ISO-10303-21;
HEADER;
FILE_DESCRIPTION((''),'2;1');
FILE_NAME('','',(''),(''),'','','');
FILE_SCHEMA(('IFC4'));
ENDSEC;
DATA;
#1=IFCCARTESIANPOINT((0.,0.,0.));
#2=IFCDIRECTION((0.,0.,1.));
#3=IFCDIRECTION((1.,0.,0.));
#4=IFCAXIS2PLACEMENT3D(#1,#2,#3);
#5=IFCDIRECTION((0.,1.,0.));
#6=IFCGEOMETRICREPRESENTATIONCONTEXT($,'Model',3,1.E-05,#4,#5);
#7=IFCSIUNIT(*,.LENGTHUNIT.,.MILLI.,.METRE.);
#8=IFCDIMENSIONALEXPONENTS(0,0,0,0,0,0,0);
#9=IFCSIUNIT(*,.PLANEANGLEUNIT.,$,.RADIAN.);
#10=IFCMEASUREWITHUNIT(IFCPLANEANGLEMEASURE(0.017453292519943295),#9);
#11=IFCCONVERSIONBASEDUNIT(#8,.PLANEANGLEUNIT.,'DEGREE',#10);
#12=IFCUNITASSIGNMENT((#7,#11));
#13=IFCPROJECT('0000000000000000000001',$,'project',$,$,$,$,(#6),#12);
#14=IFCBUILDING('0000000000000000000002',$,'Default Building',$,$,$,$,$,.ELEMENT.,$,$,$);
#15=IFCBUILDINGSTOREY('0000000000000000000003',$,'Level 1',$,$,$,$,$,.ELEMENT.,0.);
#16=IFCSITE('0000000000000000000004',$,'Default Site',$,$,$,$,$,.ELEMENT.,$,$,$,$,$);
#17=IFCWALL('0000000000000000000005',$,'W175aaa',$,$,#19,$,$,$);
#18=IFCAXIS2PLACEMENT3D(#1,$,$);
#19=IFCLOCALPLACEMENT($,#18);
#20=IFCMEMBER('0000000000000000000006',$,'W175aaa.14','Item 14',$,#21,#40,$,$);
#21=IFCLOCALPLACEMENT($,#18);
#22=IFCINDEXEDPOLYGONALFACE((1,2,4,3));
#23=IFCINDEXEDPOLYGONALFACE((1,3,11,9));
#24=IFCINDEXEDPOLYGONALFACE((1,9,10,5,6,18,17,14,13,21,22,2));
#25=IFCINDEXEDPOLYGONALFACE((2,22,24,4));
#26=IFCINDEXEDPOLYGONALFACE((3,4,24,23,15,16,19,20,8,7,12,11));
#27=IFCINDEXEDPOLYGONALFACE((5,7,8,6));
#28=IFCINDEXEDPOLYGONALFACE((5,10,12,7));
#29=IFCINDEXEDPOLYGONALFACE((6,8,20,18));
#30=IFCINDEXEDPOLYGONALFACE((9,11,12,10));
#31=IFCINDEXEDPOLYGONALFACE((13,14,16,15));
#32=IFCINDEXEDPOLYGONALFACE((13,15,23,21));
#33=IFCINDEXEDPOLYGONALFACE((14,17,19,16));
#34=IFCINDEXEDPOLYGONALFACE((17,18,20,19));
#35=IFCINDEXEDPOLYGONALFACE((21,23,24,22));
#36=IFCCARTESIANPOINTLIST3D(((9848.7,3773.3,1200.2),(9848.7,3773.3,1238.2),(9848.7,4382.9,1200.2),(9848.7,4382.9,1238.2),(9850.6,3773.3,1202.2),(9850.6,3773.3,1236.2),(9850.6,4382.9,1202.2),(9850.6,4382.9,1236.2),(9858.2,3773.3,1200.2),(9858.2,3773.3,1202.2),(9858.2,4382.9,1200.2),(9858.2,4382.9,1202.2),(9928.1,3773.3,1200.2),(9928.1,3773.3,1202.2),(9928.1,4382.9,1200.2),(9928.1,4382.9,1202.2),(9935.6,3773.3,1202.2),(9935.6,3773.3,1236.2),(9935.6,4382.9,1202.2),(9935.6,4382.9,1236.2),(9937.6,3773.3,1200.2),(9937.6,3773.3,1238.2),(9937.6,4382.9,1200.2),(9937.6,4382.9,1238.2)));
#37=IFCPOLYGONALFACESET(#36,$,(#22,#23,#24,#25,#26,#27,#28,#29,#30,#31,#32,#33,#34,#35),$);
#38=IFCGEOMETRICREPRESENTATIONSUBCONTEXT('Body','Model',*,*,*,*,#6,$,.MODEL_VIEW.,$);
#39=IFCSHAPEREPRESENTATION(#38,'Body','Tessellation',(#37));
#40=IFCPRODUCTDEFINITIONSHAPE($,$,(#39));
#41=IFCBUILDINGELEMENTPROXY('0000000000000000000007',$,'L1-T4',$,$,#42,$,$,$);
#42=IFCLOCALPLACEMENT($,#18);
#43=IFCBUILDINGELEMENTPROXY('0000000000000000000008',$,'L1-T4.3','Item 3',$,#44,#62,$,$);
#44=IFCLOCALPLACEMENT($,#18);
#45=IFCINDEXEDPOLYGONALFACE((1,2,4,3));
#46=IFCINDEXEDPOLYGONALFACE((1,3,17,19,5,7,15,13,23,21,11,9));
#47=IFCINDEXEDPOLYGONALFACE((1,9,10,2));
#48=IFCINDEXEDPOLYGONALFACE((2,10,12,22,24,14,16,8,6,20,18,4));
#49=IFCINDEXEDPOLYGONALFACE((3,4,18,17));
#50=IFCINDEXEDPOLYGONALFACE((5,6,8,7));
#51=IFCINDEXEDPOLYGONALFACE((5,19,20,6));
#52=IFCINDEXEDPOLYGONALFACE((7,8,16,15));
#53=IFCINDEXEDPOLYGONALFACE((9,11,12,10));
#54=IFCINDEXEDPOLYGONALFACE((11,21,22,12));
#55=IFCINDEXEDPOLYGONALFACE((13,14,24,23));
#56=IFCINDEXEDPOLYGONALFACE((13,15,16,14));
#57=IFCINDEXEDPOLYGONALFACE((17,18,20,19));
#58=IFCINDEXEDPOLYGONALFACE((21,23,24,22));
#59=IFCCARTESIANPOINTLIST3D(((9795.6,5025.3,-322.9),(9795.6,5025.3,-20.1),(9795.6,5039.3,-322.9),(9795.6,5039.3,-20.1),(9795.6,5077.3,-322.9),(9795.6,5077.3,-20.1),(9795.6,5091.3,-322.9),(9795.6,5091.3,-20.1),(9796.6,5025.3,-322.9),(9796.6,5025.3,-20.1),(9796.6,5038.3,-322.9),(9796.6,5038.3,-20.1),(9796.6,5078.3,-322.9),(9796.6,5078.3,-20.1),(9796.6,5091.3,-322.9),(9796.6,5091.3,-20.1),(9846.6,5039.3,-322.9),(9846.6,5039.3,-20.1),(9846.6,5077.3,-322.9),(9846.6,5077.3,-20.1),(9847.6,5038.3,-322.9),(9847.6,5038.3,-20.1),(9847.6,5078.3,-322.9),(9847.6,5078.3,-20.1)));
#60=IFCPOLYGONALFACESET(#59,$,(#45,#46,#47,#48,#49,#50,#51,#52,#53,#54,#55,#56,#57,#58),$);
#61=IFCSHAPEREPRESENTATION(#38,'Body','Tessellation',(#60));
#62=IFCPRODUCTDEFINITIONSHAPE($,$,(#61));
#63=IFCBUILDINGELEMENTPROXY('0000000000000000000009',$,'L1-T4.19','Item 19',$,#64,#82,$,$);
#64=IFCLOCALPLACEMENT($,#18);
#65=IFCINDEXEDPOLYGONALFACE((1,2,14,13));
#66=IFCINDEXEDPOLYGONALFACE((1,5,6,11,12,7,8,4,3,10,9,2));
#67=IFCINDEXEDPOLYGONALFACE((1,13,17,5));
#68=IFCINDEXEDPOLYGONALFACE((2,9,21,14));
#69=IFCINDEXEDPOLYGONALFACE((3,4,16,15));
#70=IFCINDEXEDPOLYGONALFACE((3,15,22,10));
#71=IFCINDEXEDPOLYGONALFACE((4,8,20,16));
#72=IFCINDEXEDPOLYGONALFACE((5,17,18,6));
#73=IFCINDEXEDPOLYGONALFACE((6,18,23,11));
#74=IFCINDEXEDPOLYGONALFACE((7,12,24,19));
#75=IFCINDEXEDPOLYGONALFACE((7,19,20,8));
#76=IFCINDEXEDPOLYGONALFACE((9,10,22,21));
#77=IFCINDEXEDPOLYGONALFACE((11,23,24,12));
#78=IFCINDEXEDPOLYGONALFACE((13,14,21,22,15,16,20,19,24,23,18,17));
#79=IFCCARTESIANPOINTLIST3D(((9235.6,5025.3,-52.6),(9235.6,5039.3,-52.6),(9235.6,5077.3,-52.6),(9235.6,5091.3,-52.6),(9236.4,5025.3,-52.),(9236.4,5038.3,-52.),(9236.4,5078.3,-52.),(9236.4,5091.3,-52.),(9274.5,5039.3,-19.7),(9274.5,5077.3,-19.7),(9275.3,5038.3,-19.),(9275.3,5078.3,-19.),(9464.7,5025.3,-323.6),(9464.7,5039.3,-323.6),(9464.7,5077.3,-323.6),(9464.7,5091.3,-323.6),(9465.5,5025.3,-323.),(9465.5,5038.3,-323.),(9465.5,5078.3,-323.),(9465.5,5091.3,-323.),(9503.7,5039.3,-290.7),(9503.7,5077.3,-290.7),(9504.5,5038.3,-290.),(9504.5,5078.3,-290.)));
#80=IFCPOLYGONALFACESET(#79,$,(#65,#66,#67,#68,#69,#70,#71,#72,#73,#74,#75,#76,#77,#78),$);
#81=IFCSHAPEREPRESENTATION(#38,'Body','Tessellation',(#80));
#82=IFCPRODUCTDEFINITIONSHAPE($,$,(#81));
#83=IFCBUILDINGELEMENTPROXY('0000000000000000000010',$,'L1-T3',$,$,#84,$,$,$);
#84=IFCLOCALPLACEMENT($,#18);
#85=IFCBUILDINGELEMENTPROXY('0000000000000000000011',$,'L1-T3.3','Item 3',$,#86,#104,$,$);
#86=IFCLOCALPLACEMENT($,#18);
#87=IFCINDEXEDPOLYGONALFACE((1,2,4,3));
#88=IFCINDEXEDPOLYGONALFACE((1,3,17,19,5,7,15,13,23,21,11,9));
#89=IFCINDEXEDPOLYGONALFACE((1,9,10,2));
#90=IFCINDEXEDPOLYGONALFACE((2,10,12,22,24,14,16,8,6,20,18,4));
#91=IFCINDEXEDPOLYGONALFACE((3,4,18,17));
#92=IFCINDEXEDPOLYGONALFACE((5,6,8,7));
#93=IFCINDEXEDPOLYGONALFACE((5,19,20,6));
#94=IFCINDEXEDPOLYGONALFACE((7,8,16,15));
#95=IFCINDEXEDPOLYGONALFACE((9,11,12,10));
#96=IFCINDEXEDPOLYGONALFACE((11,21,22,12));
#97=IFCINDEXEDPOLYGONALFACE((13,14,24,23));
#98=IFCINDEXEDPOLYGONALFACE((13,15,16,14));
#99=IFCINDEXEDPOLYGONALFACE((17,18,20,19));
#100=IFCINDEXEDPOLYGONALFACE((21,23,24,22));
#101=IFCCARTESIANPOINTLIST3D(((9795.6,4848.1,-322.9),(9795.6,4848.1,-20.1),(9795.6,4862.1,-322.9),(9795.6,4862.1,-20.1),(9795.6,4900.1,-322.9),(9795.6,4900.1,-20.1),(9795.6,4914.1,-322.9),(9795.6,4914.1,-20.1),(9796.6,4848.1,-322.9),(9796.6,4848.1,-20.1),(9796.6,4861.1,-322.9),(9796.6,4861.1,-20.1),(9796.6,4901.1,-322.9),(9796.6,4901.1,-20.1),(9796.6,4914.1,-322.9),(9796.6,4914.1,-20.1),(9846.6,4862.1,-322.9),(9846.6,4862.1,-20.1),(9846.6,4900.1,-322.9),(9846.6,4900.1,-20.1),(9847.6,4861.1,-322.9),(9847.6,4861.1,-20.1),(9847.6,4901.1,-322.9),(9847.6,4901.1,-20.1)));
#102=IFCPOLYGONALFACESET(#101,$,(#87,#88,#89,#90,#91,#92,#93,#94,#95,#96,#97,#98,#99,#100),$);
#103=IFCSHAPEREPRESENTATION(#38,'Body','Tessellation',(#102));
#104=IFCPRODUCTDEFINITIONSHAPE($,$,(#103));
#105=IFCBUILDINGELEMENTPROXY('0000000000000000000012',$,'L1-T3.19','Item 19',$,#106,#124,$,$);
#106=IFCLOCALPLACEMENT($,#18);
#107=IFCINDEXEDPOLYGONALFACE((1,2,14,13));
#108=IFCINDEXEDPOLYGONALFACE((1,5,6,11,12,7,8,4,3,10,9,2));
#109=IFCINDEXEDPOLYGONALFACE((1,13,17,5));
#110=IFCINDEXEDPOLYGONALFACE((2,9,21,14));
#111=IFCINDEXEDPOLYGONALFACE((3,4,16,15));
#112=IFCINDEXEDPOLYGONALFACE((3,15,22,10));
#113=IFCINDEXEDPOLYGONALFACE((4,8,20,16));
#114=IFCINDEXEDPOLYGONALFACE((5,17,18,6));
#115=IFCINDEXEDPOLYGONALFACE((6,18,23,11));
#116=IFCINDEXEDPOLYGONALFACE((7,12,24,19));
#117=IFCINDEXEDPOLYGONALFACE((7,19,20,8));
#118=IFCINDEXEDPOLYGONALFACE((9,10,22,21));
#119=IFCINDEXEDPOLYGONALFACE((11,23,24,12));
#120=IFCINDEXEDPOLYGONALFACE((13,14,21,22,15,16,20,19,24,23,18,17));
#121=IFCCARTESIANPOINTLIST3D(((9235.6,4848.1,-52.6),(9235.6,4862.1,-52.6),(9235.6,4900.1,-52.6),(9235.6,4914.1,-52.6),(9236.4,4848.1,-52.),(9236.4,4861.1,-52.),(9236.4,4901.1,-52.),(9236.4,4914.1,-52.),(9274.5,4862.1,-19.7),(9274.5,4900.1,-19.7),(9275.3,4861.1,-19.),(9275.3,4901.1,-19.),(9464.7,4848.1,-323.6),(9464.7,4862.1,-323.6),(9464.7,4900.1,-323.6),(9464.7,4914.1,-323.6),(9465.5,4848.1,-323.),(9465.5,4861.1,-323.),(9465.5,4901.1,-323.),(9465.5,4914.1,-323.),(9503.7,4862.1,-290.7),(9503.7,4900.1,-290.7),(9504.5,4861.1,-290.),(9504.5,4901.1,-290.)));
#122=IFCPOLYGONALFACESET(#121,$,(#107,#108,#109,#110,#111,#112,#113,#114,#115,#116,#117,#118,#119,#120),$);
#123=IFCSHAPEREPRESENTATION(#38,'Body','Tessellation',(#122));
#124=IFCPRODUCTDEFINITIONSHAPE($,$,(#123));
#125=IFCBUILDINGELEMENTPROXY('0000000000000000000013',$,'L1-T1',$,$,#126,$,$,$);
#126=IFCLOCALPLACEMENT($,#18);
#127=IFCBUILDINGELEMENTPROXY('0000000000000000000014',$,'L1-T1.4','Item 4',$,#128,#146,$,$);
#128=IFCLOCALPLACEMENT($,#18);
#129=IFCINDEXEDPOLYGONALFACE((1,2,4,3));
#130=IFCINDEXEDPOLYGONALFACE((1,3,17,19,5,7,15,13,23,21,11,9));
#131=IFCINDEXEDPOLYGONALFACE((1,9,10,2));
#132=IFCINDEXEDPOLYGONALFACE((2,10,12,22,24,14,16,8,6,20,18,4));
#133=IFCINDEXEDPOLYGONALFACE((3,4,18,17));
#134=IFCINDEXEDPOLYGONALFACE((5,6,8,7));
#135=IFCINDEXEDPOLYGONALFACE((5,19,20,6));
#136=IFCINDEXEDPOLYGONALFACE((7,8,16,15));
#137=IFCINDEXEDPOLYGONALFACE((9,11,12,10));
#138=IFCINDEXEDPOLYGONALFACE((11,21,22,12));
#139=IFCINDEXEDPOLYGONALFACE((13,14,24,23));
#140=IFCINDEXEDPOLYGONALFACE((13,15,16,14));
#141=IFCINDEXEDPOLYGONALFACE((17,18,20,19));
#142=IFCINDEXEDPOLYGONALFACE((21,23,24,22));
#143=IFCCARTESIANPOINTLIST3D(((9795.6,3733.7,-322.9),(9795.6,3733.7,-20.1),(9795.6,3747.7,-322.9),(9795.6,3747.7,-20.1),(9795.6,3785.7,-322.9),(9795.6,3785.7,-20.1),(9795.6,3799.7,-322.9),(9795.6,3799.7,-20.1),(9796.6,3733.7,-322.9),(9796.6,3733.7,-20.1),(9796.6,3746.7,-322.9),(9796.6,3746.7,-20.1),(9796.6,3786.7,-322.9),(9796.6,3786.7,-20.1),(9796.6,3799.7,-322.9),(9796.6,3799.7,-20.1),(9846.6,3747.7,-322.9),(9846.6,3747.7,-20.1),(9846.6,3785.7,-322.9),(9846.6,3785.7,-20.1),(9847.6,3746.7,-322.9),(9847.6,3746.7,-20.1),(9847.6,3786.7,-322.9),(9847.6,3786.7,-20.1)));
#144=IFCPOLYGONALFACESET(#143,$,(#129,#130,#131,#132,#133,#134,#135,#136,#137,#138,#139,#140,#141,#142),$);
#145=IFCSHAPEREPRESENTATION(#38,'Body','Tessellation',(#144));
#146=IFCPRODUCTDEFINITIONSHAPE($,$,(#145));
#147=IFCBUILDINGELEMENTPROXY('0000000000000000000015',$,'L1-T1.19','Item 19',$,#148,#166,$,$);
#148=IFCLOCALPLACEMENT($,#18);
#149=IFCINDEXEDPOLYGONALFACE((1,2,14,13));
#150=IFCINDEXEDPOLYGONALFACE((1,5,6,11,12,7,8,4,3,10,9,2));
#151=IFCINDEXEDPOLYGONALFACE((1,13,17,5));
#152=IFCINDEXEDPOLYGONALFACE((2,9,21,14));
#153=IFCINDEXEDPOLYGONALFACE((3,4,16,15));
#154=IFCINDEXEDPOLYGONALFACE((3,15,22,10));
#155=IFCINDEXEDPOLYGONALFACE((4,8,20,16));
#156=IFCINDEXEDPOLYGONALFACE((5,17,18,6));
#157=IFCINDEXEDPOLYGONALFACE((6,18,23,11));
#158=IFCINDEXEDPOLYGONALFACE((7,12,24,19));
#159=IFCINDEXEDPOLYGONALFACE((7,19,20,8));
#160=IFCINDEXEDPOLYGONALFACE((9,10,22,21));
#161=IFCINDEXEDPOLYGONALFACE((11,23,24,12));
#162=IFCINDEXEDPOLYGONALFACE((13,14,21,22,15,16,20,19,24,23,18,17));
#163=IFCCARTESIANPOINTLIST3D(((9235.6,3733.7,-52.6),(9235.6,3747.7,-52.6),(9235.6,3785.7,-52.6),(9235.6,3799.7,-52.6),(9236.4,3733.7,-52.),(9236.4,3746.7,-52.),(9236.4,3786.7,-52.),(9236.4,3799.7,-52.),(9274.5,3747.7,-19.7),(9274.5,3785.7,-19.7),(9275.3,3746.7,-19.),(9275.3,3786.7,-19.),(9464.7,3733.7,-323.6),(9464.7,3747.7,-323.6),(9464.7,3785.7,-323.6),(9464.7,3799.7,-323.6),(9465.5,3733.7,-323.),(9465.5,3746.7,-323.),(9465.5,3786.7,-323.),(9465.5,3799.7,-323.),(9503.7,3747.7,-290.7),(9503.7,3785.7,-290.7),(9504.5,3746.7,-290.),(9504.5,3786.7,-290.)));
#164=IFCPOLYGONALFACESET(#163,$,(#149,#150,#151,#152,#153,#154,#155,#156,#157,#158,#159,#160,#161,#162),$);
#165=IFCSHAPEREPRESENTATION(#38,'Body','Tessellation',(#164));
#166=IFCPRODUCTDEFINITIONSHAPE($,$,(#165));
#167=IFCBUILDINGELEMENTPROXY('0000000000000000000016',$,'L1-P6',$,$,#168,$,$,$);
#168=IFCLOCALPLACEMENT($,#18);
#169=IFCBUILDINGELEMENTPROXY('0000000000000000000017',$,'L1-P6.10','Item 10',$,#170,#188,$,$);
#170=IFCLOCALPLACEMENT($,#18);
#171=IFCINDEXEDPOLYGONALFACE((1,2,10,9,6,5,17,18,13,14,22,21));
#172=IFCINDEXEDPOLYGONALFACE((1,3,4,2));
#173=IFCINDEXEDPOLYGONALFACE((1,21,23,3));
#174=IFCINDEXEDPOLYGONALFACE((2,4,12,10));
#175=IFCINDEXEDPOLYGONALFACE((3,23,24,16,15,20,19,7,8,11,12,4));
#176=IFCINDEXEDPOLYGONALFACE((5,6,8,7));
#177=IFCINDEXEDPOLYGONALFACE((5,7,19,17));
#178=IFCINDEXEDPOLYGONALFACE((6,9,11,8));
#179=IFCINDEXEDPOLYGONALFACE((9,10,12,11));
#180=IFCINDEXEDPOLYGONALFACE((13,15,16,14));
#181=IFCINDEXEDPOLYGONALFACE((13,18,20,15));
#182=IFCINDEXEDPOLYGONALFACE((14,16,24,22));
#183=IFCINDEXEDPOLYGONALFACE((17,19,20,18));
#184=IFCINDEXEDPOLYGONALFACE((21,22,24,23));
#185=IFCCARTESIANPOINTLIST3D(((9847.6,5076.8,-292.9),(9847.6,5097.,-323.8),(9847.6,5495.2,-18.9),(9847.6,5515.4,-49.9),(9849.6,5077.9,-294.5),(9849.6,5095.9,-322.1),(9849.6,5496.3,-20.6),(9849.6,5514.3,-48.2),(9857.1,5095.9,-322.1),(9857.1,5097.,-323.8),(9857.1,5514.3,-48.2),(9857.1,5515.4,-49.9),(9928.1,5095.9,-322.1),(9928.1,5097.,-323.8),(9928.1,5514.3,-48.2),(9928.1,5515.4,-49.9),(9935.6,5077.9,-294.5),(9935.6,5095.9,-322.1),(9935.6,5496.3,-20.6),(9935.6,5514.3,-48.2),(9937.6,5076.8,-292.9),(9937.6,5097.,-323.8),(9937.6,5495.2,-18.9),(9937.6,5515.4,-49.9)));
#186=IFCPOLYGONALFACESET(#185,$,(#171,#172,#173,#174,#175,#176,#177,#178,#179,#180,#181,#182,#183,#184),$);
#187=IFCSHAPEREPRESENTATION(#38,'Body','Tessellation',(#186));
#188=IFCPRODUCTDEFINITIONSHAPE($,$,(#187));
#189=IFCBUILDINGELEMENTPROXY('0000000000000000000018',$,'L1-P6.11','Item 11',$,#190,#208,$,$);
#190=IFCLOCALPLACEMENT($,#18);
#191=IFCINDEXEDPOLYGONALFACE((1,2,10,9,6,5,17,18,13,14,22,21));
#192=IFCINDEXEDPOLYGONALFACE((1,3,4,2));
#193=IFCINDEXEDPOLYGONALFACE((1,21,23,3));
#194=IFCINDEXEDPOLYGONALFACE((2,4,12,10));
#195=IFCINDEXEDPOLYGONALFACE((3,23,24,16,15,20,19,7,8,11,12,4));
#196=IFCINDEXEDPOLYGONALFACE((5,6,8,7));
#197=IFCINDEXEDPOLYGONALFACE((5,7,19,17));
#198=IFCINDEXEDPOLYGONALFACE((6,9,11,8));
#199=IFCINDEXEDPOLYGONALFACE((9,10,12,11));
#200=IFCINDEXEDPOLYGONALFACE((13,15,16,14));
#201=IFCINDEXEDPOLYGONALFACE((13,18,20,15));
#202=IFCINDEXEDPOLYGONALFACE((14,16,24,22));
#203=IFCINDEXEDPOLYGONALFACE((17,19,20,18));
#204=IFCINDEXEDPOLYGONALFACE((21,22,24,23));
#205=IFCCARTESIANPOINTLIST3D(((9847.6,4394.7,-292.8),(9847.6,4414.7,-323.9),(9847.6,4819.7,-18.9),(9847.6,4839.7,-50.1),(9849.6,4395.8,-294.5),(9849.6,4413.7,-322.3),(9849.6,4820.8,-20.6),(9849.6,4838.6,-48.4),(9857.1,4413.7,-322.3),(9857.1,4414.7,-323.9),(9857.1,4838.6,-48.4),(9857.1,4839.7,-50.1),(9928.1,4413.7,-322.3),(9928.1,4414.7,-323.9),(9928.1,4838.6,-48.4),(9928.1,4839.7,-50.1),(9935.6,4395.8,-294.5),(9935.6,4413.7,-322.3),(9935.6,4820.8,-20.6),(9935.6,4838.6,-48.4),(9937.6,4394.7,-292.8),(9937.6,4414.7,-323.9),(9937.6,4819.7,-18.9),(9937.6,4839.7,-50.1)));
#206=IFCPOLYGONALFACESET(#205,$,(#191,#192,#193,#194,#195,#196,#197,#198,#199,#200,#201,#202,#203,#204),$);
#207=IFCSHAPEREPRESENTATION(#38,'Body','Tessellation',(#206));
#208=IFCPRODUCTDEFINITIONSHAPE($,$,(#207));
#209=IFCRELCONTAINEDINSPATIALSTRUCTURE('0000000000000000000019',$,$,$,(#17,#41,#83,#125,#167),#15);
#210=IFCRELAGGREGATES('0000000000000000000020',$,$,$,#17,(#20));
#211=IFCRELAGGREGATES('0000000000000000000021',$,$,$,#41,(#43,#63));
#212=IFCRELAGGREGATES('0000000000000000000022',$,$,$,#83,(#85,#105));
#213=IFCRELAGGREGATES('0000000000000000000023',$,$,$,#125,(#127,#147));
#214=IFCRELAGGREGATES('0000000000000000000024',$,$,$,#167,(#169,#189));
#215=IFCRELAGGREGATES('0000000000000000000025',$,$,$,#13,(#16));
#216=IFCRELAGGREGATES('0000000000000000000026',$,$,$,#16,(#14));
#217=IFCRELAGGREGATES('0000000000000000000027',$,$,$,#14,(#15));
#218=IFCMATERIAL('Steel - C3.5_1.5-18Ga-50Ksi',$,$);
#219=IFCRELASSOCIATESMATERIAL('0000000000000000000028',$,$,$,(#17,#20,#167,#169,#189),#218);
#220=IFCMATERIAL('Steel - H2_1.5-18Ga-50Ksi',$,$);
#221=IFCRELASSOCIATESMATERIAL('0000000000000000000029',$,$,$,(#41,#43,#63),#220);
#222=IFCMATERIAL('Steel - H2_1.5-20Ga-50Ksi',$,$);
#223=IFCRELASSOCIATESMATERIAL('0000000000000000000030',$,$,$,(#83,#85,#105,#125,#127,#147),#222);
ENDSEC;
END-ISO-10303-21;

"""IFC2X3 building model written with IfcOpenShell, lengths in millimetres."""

from ifc_helpers import new_model, entity, si_unit, converted_unit, direction, frame, origin, origin_with_axes, origin_2d_with_axis, place, context, subcontext, project, spatial, polyline, c_section, outline, extrude, material, element, aggregate, save


model = new_model("IFC2X3")

# Units and contexts
model_context = context("Model", 3, precision=1e-05, world=origin_with_axes(), true_north=direction((0.0, 1.0, 0.0)))
body_context = subcontext(model_context, "Body", "Model", "MODEL_VIEW")
ifc_project = project(units=[si_unit("LENGTHUNIT", "METRE", prefix="MILLI"), converted_unit("PLANEANGLEUNIT", "DEGREE", entity("IfcPlaneAngleMeasure", 0.017453292519943295), si_unit("PLANEANGLEUNIT", "RADIAN"), dimensions=[0, 0, 0, 0, 0, 0, 0])], contexts=[model_context])

# Site, building, storey
site = spatial("IfcSite", under=ifc_project, Name="Default Site", CompositionType="ELEMENT")
building = spatial("IfcBuilding", under=site, Name="Default Building", CompositionType="ELEMENT")
storey = spatial("IfcBuildingStorey", under=building, Name="Level 1", CompositionType="ELEMENT", Elevation=0.0)

# Wall, member
ifc_material_1 = material(Name="Steel - C3.5_1.5-18Ga-50Ksi")
wall = element("IfcWall", 1, inside=storey, material=ifc_material_1, Name="W175aaa")
member_1_placement = place(None, frame((9893.1, 3773.3, 1219.2), z_axis=(0.0, 1.0, 0.0), x_axis=(0.0, 0.0, -1.0)))
member_1 = element("IfcMember", 2, at=member_1_placement, material=ifc_material_1, Name="W175aaa.14", Description="Item 14", context=body_context, shape_type="SweptSolid", body=[
    extrude(c_section(Depth=88.9, Width=38.1, WallThickness=2.0, Girth=9.5, at=origin_2d_with_axis()), origin(), (0.0, 0.0, 1.0), 609.6),
])
aggregate(wall, [member_1])

# Building element proxies
ifc_material_2 = material(Name="Steel - H2_1.5-18Ga-50Ksi")
proxy_1 = element("IfcBuildingElementProxy", 3, inside=storey, material=ifc_material_2, Name="L1-T4")
proxy_2_placement = place(None, frame((9795.6, 5025.3, -20.1), z_axis=(0.0, 0.0, -1.0), x_axis=(0.0, 40.0, 0.0)))
proxy_2 = element("IfcBuildingElementProxy", 4, at=proxy_2_placement, material=ifc_material_2, Name="L1-T4.3", Description="Item 3", context=body_context, shape_type="SweptSolid", body=[
    extrude(outline(polyline([(0.0, 0.0), (14.0, 0.0), (14.0, 51.0), (52.0, 51.0), (52.0, 0.0), (66.0, 0.0), (66.0, 1.0), (53.0, 1.0), (53.0, 52.0), (13.0, 52.0), (13.0, 1.0), (0.0, 1.0), (0.0, 0.0)])), origin(), (0.0, 0.0, 1.0), 302.8),
])
proxy_3_placement = place(None, frame((9235.6, 5025.3, -52.6), z_axis=(0.646, 0.0, -0.764), x_axis=(0.0, 40.0, 0.0)))
proxy_3 = element("IfcBuildingElementProxy", 5, at=proxy_3_placement, material=ifc_material_2, Name="L1-T4.19", Description="Item 19", context=body_context, shape_type="SweptSolid", body=[
    extrude(outline(polyline([(0.0, 0.0), (14.0, 0.0), (14.0, 51.0), (52.0, 51.0), (52.0, 0.0), (66.0, 0.0), (66.0, 1.0), (53.0, 1.0), (53.0, 52.0), (13.0, 52.0), (13.0, 1.0), (0.0, 1.0), (0.0, 0.0)])), origin(), (0.0, 0.0, 1.0), 354.9),
])
aggregate(proxy_1, [proxy_2, proxy_3])
ifc_material_3 = material(Name="Steel - H2_1.5-20Ga-50Ksi")
proxy_4 = element("IfcBuildingElementProxy", 6, inside=storey, material=ifc_material_3, Name="L1-T3")
proxy_5_placement = place(None, frame((9795.6, 4848.1, -20.1), z_axis=(0.0, 0.0, -1.0), x_axis=(0.0, 40.0, 0.0)))
proxy_5 = element("IfcBuildingElementProxy", 7, at=proxy_5_placement, material=ifc_material_3, Name="L1-T3.3", Description="Item 3", context=body_context, shape_type="SweptSolid", body=[
    extrude(outline(polyline([(0.0, 0.0), (14.0, 0.0), (14.0, 51.0), (52.0, 51.0), (52.0, 0.0), (66.0, 0.0), (66.0, 1.0), (53.0, 1.0), (53.0, 52.0), (13.0, 52.0), (13.0, 1.0), (0.0, 1.0), (0.0, 0.0)])), origin(), (0.0, 0.0, 1.0), 302.8),
])
proxy_6_placement = place(None, frame((9235.6, 4848.1, -52.6), z_axis=(0.646, 0.0, -0.764), x_axis=(0.0, 40.0, 0.0)))
proxy_6 = element("IfcBuildingElementProxy", 8, at=proxy_6_placement, material=ifc_material_3, Name="L1-T3.19", Description="Item 19", context=body_context, shape_type="SweptSolid", body=[
    extrude(outline(polyline([(0.0, 0.0), (14.0, 0.0), (14.0, 51.0), (52.0, 51.0), (52.0, 0.0), (66.0, 0.0), (66.0, 1.0), (53.0, 1.0), (53.0, 52.0), (13.0, 52.0), (13.0, 1.0), (0.0, 1.0), (0.0, 0.0)])), origin(), (0.0, 0.0, 1.0), 354.9),
])
aggregate(proxy_4, [proxy_5, proxy_6])
proxy_7 = element("IfcBuildingElementProxy", 9, inside=storey, material=ifc_material_3, Name="L1-T1")
proxy_8_placement = place(None, frame((9795.6, 3733.7, -20.1), z_axis=(0.0, 0.0, -1.0), x_axis=(0.0, 40.0, 0.0)))
proxy_8 = element("IfcBuildingElementProxy", 10, at=proxy_8_placement, material=ifc_material_3, Name="L1-T1.4", Description="Item 4", context=body_context, shape_type="SweptSolid", body=[
    extrude(outline(polyline([(0.0, 0.0), (14.0, 0.0), (14.0, 51.0), (52.0, 51.0), (52.0, 0.0), (66.0, 0.0), (66.0, 1.0), (53.0, 1.0), (53.0, 52.0), (13.0, 52.0), (13.0, 1.0), (0.0, 1.0), (0.0, 0.0)])), origin(), (0.0, 0.0, 1.0), 302.8),
])
proxy_9_placement = place(None, frame((9235.6, 3733.7, -52.6), z_axis=(0.646, 0.0, -0.764), x_axis=(0.0, 40.0, 0.0)))
proxy_9 = element("IfcBuildingElementProxy", 11, at=proxy_9_placement, material=ifc_material_3, Name="L1-T1.19", Description="Item 19", context=body_context, shape_type="SweptSolid", body=[
    extrude(outline(polyline([(0.0, 0.0), (14.0, 0.0), (14.0, 51.0), (52.0, 51.0), (52.0, 0.0), (66.0, 0.0), (66.0, 1.0), (53.0, 1.0), (53.0, 52.0), (13.0, 52.0), (13.0, 1.0), (0.0, 1.0), (0.0, 0.0)])), origin(), (0.0, 0.0, 1.0), 354.9),
])
aggregate(proxy_7, [proxy_8, proxy_9])
proxy_10 = element("IfcBuildingElementProxy", 12, inside=storey, material=ifc_material_1, Name="L1-P6")
proxy_11_placement = place(None, frame((9892.6, 5505.3, -34.4), z_axis=(0.0, -0.837, -0.548), x_axis=(0.0, 20.267, -30.956)))
proxy_11 = element("IfcBuildingElementProxy", 13, at=proxy_11_placement, material=ifc_material_1, Name="L1-P6.10", Description="Item 10", context=body_context, shape_type="SweptSolid", body=[
    extrude(c_section(Depth=90.0, Width=37.0, WallThickness=2.0, Girth=9.5, at=origin_2d_with_axis()), origin(), (0.0, 0.0, 1.0), 500.1),
])
proxy_12_placement = place(None, frame((9892.6, 4829.7, -34.5), z_axis=(0.0, -0.841, -0.542), x_axis=(0.0, 20.041, -31.103)))
proxy_12 = element("IfcBuildingElementProxy", 14, at=proxy_12_placement, material=ifc_material_1, Name="L1-P6.11", Description="Item 11", context=body_context, shape_type="SweptSolid", body=[
    extrude(c_section(Depth=90.0, Width=37.0, WallThickness=2.0, Girth=9.5, at=origin_2d_with_axis()), origin(), (0.0, 0.0, 1.0), 505.6),
])
aggregate(proxy_10, [proxy_11, proxy_12])

save(model, "model.ifc")
